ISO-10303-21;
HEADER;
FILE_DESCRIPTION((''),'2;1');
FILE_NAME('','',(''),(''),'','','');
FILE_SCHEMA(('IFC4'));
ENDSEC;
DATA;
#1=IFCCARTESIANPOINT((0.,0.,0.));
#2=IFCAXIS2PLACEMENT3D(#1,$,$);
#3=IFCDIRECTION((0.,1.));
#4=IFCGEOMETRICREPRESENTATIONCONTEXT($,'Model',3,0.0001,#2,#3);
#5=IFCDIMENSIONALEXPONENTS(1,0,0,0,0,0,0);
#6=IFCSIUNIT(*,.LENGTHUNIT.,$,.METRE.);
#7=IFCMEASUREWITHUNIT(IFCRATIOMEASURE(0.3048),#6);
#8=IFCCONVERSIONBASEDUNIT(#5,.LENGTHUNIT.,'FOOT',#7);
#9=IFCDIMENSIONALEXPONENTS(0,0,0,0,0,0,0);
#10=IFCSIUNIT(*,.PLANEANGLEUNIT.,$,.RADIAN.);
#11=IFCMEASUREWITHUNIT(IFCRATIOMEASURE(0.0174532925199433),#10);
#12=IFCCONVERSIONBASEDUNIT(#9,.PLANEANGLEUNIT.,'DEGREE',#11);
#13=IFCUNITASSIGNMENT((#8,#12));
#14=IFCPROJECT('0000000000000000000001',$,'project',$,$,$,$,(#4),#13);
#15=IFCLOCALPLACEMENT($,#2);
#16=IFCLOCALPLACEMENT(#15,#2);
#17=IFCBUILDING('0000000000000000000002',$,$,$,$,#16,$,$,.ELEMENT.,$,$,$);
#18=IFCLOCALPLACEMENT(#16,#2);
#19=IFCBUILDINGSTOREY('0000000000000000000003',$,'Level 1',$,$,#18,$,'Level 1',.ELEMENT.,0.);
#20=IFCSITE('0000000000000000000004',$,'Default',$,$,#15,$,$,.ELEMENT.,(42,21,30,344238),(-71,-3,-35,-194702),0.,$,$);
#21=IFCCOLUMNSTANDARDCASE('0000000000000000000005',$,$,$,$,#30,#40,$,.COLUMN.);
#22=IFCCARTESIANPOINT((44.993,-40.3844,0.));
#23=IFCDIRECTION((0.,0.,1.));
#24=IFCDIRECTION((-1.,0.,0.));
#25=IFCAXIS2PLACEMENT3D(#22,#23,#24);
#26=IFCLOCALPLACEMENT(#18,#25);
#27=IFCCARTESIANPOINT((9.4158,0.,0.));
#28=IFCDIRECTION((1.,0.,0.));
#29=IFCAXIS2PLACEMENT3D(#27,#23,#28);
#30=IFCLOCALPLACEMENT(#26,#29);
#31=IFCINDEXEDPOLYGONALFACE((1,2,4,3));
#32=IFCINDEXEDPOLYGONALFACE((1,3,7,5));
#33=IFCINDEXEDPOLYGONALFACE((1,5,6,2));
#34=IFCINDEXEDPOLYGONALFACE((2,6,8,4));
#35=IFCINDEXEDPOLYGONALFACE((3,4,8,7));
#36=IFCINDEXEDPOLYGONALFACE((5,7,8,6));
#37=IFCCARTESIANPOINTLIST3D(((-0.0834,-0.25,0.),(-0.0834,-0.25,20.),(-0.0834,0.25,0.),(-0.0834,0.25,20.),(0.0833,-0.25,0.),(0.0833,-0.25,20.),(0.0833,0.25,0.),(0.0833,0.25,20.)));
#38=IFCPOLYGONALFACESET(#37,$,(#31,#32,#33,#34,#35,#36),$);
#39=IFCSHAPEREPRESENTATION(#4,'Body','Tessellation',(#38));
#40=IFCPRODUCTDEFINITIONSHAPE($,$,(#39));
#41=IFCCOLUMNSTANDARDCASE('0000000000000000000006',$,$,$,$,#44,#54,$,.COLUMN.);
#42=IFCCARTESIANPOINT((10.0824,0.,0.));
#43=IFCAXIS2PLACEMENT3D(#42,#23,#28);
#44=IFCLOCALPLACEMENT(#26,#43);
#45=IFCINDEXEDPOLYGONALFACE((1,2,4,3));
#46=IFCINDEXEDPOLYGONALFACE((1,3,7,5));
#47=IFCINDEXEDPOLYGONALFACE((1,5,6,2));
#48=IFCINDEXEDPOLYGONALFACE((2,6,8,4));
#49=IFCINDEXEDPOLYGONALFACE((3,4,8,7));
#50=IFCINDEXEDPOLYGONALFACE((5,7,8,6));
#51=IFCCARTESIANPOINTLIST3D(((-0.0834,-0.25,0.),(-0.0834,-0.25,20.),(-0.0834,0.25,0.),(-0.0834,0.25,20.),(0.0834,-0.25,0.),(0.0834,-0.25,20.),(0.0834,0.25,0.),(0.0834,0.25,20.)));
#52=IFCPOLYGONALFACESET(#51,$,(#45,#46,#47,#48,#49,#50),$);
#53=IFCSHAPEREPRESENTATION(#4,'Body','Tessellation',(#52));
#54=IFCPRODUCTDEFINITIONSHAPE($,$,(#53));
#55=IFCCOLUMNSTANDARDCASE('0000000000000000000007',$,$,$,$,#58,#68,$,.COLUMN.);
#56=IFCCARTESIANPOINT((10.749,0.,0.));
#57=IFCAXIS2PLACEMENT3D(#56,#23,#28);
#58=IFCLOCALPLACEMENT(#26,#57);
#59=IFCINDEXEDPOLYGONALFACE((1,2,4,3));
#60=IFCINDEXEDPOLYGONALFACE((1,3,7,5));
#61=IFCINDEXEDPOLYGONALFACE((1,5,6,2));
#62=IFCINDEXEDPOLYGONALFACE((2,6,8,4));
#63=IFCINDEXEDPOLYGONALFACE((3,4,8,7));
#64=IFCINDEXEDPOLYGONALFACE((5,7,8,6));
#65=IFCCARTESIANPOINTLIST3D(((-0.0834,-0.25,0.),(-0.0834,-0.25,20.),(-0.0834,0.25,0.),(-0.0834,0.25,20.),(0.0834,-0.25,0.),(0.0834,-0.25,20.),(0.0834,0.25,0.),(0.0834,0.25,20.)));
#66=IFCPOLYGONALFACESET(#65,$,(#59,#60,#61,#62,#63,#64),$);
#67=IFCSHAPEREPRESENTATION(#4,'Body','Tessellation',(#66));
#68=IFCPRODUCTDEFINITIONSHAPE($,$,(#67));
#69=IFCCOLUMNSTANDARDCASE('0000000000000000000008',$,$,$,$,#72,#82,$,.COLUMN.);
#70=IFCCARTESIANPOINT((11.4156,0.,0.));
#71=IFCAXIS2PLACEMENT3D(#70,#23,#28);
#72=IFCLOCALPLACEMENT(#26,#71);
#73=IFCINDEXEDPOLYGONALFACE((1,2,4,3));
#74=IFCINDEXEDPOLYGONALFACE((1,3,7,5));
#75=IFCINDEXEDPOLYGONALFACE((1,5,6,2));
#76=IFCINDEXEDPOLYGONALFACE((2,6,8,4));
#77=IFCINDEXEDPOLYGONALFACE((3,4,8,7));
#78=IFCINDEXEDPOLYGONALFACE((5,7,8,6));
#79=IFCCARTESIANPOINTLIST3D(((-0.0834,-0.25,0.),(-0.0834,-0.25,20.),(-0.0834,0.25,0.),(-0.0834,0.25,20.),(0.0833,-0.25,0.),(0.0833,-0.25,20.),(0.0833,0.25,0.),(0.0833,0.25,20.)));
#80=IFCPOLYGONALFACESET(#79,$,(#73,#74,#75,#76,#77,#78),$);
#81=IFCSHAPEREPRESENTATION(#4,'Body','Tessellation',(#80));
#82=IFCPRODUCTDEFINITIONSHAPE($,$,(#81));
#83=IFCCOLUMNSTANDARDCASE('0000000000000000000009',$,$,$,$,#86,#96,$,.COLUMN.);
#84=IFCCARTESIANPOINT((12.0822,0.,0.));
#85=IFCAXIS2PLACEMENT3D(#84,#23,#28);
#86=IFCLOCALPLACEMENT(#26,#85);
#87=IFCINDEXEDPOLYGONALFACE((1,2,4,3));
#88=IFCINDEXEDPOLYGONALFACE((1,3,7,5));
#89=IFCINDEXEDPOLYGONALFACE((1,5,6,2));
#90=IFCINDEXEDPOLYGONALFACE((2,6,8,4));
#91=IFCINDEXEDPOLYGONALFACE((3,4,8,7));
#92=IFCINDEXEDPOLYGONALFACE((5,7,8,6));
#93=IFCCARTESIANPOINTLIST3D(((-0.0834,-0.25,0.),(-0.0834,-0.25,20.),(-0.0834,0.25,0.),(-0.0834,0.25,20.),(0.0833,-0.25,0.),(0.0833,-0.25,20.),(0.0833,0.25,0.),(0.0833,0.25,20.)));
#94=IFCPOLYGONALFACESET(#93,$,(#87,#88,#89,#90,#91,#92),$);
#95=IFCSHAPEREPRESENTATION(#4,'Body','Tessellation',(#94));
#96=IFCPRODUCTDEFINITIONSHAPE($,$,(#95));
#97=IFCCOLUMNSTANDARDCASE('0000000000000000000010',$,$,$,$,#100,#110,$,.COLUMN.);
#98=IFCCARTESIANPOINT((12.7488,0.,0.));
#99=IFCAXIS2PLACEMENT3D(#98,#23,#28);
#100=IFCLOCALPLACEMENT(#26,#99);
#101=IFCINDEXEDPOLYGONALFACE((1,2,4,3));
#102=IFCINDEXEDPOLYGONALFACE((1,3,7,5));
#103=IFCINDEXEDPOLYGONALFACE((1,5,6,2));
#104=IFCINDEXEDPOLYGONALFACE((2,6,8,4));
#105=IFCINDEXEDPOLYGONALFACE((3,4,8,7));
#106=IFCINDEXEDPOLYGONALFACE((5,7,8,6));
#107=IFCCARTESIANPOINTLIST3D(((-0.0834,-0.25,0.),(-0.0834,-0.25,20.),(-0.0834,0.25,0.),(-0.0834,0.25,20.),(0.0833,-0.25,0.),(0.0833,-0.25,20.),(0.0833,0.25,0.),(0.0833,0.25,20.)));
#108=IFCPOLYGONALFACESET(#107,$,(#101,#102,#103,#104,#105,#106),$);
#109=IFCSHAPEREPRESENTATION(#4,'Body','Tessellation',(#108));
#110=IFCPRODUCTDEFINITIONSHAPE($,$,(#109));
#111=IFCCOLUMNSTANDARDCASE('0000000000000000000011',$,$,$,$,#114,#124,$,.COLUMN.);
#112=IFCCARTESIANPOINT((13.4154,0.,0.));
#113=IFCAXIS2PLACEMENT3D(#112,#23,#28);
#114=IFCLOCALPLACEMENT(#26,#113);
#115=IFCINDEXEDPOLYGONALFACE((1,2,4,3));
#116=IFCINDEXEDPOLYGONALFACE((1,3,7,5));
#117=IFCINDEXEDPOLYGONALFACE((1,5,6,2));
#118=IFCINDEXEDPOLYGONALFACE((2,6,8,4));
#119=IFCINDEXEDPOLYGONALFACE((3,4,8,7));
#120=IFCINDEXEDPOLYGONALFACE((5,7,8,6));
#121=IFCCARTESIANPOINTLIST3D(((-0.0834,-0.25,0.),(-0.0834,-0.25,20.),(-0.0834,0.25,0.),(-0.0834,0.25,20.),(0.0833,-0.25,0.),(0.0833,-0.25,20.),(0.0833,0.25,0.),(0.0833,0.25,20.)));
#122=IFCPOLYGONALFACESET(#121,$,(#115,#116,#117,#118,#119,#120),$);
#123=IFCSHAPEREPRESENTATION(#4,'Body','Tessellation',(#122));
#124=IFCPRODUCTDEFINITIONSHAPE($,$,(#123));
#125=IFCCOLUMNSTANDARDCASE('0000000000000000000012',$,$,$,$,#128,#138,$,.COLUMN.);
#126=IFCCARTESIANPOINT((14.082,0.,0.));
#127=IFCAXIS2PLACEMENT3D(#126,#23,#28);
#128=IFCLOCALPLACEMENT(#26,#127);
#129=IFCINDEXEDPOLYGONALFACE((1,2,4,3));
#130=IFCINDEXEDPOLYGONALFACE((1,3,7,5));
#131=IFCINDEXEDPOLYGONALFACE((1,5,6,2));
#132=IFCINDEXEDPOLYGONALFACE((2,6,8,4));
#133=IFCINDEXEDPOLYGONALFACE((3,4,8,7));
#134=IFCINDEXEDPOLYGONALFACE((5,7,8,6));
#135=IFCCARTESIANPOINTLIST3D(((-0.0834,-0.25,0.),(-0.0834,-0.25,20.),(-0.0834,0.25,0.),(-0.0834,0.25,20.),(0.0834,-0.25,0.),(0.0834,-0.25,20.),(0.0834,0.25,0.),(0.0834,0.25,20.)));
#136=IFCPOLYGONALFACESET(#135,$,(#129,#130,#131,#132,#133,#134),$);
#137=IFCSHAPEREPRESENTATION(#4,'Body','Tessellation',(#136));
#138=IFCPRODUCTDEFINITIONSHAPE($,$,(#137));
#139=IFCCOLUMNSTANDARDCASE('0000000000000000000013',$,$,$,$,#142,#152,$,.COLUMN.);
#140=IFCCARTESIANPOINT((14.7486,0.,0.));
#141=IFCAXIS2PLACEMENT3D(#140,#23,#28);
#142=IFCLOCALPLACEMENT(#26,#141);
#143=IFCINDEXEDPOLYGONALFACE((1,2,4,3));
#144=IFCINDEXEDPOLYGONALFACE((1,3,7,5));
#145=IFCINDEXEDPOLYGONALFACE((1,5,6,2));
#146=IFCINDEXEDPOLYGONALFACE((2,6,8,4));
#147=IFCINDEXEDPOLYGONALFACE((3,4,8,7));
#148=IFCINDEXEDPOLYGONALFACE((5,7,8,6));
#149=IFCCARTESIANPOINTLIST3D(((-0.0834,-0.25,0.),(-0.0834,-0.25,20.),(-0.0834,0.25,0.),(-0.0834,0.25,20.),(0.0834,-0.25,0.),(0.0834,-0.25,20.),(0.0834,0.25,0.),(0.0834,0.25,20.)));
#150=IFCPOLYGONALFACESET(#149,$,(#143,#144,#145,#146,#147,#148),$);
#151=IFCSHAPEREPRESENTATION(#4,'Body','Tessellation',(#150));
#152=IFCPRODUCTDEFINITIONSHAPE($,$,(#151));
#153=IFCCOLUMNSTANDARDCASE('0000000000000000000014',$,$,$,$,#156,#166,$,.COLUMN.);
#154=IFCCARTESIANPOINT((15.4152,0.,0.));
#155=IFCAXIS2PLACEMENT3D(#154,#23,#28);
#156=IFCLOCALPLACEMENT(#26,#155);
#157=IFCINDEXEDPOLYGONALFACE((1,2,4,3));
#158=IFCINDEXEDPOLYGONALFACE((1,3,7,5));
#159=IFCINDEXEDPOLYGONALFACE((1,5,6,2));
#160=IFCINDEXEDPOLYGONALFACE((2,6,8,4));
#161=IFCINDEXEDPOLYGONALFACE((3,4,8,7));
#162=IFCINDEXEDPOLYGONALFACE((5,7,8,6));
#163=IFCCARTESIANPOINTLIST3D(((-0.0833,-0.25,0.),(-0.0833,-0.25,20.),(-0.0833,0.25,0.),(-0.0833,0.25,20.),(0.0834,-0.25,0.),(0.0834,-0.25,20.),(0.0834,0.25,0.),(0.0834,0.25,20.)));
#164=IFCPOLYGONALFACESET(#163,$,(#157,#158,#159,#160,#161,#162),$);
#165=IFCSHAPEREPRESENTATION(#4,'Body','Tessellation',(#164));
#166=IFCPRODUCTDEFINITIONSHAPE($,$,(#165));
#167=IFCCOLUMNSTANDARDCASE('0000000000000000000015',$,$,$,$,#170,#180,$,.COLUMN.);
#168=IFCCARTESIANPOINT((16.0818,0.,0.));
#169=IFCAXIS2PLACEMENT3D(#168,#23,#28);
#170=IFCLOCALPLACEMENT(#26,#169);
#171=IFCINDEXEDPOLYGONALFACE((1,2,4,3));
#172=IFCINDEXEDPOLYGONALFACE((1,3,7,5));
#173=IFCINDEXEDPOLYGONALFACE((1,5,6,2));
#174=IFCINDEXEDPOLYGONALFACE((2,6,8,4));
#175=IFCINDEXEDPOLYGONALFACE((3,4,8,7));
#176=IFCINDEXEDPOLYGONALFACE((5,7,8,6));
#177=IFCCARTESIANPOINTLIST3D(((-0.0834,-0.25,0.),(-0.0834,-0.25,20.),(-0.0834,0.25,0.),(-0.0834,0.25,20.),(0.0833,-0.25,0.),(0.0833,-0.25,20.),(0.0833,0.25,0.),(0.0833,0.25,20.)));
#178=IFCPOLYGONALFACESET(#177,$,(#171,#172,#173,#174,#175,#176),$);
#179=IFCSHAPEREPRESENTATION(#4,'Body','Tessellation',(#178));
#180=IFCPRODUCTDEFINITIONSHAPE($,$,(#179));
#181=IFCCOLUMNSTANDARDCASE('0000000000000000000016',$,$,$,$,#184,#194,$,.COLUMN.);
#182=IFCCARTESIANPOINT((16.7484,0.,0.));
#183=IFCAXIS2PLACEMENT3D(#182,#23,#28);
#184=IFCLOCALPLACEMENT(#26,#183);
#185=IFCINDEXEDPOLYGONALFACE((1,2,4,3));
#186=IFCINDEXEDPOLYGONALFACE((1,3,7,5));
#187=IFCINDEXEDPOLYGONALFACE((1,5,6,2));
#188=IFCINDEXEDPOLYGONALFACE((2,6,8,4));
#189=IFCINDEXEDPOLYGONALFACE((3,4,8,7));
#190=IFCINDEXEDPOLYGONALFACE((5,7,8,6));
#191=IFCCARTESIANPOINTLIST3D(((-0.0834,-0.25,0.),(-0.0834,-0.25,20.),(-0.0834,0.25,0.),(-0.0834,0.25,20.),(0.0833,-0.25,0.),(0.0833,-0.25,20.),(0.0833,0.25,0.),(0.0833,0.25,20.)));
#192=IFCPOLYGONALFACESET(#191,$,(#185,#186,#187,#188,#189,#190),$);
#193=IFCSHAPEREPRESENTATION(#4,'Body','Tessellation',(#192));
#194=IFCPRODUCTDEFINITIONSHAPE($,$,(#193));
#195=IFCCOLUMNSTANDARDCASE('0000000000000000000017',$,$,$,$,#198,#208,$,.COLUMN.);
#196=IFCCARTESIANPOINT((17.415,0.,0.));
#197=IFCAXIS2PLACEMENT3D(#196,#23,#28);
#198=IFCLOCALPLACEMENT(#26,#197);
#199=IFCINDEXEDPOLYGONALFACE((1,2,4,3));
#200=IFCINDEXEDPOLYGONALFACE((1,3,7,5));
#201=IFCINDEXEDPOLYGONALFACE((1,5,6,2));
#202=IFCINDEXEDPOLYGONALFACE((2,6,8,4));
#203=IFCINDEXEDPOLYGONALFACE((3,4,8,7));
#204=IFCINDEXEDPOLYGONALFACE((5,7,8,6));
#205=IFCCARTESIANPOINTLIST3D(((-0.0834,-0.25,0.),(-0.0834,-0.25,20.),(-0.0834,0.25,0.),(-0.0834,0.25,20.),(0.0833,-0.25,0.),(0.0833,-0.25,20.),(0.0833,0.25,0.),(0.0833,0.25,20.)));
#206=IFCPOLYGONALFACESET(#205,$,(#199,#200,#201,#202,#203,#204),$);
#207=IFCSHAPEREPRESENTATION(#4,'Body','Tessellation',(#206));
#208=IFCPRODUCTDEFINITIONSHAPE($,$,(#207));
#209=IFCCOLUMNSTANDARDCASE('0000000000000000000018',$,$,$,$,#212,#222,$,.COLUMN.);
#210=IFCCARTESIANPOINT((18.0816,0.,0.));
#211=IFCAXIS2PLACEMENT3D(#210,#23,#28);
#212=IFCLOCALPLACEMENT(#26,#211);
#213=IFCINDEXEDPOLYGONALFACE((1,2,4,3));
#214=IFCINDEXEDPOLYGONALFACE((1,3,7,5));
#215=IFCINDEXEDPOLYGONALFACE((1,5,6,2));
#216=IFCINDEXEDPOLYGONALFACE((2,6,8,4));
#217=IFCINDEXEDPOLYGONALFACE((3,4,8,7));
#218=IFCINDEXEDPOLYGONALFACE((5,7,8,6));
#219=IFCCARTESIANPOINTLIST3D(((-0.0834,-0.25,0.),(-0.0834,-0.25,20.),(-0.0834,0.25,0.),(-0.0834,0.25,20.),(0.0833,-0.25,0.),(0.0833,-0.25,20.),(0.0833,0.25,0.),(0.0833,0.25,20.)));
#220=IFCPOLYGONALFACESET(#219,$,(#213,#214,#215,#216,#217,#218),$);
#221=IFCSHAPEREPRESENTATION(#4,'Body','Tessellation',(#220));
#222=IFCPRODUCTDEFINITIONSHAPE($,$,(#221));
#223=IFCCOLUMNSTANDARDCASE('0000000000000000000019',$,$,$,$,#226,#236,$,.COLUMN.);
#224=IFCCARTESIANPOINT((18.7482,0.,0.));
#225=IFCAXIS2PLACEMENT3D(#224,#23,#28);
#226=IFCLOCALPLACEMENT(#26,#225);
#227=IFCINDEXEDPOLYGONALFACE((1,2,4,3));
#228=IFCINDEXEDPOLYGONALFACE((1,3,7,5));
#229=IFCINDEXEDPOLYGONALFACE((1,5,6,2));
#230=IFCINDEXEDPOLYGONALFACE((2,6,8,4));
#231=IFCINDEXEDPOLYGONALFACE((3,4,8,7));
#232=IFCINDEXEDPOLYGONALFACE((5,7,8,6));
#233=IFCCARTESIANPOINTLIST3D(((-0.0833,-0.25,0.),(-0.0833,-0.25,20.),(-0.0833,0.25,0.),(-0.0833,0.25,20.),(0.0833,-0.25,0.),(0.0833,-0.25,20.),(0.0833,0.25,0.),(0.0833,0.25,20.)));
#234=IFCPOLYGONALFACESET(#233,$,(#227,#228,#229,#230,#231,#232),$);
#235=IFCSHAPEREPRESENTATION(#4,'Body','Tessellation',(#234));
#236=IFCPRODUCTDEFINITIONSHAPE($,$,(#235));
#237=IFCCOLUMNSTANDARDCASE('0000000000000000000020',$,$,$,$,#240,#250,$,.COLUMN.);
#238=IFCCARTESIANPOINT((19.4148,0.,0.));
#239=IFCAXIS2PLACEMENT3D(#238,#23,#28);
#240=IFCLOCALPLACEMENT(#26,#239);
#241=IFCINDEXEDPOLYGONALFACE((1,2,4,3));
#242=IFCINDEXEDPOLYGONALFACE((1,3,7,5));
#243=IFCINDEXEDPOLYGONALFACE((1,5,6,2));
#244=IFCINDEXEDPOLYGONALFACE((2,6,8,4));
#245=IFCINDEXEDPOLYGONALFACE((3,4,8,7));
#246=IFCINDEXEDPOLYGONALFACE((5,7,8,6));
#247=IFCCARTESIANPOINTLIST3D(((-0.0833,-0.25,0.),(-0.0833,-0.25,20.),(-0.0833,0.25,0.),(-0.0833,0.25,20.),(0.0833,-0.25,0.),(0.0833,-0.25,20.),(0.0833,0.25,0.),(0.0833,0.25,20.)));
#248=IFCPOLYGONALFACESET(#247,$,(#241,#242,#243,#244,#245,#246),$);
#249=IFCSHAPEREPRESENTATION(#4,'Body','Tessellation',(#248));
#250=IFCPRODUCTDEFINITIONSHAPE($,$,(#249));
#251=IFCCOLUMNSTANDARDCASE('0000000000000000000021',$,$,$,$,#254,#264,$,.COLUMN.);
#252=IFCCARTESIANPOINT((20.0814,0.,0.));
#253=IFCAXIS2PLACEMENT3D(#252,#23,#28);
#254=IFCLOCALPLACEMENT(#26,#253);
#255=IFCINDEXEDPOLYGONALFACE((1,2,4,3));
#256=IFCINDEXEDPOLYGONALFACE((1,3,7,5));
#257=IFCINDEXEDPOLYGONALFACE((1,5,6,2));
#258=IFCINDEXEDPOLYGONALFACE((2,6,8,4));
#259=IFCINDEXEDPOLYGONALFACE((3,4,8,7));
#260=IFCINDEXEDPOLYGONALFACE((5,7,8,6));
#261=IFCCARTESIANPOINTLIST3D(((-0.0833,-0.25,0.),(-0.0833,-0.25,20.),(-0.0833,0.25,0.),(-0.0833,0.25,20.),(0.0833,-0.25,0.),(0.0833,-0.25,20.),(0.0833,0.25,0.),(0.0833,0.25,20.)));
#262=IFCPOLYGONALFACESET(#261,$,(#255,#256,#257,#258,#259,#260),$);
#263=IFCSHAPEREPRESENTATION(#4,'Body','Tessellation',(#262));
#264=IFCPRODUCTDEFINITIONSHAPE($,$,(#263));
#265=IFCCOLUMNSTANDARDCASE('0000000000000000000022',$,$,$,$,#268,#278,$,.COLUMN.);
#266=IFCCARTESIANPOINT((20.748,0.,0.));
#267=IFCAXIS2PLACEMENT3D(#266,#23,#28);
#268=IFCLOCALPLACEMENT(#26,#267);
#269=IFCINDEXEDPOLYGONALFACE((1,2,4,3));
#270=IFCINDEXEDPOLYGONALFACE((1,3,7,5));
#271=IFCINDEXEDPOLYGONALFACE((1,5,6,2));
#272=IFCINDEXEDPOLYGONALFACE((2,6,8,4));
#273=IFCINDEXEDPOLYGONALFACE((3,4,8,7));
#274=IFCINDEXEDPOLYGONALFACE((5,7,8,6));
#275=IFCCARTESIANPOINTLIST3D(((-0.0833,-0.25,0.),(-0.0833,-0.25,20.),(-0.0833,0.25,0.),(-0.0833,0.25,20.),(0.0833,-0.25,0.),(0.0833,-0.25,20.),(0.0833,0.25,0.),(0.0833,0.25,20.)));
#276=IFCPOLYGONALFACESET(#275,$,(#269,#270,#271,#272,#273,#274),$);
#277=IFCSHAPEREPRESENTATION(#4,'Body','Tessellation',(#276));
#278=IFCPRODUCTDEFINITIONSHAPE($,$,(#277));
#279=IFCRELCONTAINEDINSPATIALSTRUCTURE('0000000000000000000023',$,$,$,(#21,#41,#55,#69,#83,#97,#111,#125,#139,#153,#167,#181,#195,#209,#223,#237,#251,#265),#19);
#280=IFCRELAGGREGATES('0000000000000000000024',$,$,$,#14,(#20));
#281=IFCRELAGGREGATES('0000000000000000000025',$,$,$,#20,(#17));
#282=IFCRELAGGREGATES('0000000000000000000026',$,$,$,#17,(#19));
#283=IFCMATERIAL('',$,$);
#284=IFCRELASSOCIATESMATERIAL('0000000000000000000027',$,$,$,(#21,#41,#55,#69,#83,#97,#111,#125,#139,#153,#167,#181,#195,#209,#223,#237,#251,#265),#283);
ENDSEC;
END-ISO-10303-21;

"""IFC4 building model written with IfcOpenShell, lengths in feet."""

from ifc_helpers import new_model, entity, si_unit, converted_unit, direction, frame, origin, place, context, project, spatial, rectangle, extrude, material, element, save


model = new_model("IFC4")

# Units and contexts
model_context = context("Model", 3, precision=0.0001, world=origin(), true_north=direction((0.0, 1.0)))
ifc_project = project(units=[converted_unit("LENGTHUNIT", "FOOT", entity("IfcRatioMeasure", 0.3048), si_unit("LENGTHUNIT", "METRE"), dimensions=[1, 0, 0, 0, 0, 0, 0]), converted_unit("PLANEANGLEUNIT", "DEGREE", entity("IfcRatioMeasure", 0.0174532925199433), si_unit("PLANEANGLEUNIT", "RADIAN"), dimensions=[0, 0, 0, 0, 0, 0, 0])], contexts=[model_context])

# Site, building, storey
site_placement = place(None, origin())
site = spatial("IfcSite", under=ifc_project, at=site_placement, Name="Default", CompositionType="ELEMENT", RefLatitude=(42, 21, 30, 344238), RefLongitude=(-71, -3, -35, -194702), RefElevation=0.0)
building_placement = place(site_placement, origin())
building = spatial("IfcBuilding", under=site, at=building_placement, CompositionType="ELEMENT")
storey_placement = place(building_placement, origin())
storey = spatial("IfcBuildingStorey", under=building, at=storey_placement, Name="Level 1", LongName="Level 1", CompositionType="ELEMENT", Elevation=0.0)

# Columns
ifc_material = material(Name="")
placement = place(storey_placement, frame((44.993, -40.3844, 0.0), z_axis=(0.0, 0.0, 1.0), x_axis=(-1.0, 0.0, 0.0)))
for number, where, z_axis, x_axis in (
    (1, (9.4158, 0.0, 0.0), (0.0, 0.0, 1.0), (1.0, 0.0, 0.0)),
    (2, (10.0824, 0.0, 0.0), (0.0, 0.0, 1.0), (1.0, 0.0, 0.0)),
    (3, (10.749, 0.0, 0.0), (0.0, 0.0, 1.0), (1.0, 0.0, 0.0)),
    (4, (11.4156, 0.0, 0.0), (0.0, 0.0, 1.0), (1.0, 0.0, 0.0)),
    (5, (12.0822, 0.0, 0.0), (0.0, 0.0, 1.0), (1.0, 0.0, 0.0)),
    (6, (12.7488, 0.0, 0.0), (0.0, 0.0, 1.0), (1.0, 0.0, 0.0)),
    (7, (13.4154, 0.0, 0.0), (0.0, 0.0, 1.0), (1.0, 0.0, 0.0)),
    (8, (14.082, 0.0, 0.0), (0.0, 0.0, 1.0), (1.0, 0.0, 0.0)),
    (9, (14.7486, 0.0, 0.0), (0.0, 0.0, 1.0), (1.0, 0.0, 0.0)),
    (10, (15.4152, 0.0, 0.0), (0.0, 0.0, 1.0), (1.0, 0.0, 0.0)),
    (11, (16.0818, 0.0, 0.0), (0.0, 0.0, 1.0), (1.0, 0.0, 0.0)),
    (12, (16.7484, 0.0, 0.0), (0.0, 0.0, 1.0), (1.0, 0.0, 0.0)),
    (13, (17.415, 0.0, 0.0), (0.0, 0.0, 1.0), (1.0, 0.0, 0.0)),
    (14, (18.0816, 0.0, 0.0), (0.0, 0.0, 1.0), (1.0, 0.0, 0.0)),
    (15, (18.7482, 0.0, 0.0), (0.0, 0.0, 1.0), (1.0, 0.0, 0.0)),
    (16, (19.4148, 0.0, 0.0), (0.0, 0.0, 1.0), (1.0, 0.0, 0.0)),
    (17, (20.0814, 0.0, 0.0), (0.0, 0.0, 1.0), (1.0, 0.0, 0.0)),
    (18, (20.748, 0.0, 0.0), (0.0, 0.0, 1.0), (1.0, 0.0, 0.0)),
):
    element("IfcColumnStandardCase", number, at=place(placement, frame(where, z_axis=z_axis, x_axis=x_axis)), inside=storey, material=ifc_material, PredefinedType="COLUMN", context=model_context, shape_type="SweptSolid", body=[
        extrude(rectangle(XDim=0.1667, YDim=0.5), origin(), (0.0, 0.0, 1.0), 20.0),
    ])

save(model, "model.ifc")
